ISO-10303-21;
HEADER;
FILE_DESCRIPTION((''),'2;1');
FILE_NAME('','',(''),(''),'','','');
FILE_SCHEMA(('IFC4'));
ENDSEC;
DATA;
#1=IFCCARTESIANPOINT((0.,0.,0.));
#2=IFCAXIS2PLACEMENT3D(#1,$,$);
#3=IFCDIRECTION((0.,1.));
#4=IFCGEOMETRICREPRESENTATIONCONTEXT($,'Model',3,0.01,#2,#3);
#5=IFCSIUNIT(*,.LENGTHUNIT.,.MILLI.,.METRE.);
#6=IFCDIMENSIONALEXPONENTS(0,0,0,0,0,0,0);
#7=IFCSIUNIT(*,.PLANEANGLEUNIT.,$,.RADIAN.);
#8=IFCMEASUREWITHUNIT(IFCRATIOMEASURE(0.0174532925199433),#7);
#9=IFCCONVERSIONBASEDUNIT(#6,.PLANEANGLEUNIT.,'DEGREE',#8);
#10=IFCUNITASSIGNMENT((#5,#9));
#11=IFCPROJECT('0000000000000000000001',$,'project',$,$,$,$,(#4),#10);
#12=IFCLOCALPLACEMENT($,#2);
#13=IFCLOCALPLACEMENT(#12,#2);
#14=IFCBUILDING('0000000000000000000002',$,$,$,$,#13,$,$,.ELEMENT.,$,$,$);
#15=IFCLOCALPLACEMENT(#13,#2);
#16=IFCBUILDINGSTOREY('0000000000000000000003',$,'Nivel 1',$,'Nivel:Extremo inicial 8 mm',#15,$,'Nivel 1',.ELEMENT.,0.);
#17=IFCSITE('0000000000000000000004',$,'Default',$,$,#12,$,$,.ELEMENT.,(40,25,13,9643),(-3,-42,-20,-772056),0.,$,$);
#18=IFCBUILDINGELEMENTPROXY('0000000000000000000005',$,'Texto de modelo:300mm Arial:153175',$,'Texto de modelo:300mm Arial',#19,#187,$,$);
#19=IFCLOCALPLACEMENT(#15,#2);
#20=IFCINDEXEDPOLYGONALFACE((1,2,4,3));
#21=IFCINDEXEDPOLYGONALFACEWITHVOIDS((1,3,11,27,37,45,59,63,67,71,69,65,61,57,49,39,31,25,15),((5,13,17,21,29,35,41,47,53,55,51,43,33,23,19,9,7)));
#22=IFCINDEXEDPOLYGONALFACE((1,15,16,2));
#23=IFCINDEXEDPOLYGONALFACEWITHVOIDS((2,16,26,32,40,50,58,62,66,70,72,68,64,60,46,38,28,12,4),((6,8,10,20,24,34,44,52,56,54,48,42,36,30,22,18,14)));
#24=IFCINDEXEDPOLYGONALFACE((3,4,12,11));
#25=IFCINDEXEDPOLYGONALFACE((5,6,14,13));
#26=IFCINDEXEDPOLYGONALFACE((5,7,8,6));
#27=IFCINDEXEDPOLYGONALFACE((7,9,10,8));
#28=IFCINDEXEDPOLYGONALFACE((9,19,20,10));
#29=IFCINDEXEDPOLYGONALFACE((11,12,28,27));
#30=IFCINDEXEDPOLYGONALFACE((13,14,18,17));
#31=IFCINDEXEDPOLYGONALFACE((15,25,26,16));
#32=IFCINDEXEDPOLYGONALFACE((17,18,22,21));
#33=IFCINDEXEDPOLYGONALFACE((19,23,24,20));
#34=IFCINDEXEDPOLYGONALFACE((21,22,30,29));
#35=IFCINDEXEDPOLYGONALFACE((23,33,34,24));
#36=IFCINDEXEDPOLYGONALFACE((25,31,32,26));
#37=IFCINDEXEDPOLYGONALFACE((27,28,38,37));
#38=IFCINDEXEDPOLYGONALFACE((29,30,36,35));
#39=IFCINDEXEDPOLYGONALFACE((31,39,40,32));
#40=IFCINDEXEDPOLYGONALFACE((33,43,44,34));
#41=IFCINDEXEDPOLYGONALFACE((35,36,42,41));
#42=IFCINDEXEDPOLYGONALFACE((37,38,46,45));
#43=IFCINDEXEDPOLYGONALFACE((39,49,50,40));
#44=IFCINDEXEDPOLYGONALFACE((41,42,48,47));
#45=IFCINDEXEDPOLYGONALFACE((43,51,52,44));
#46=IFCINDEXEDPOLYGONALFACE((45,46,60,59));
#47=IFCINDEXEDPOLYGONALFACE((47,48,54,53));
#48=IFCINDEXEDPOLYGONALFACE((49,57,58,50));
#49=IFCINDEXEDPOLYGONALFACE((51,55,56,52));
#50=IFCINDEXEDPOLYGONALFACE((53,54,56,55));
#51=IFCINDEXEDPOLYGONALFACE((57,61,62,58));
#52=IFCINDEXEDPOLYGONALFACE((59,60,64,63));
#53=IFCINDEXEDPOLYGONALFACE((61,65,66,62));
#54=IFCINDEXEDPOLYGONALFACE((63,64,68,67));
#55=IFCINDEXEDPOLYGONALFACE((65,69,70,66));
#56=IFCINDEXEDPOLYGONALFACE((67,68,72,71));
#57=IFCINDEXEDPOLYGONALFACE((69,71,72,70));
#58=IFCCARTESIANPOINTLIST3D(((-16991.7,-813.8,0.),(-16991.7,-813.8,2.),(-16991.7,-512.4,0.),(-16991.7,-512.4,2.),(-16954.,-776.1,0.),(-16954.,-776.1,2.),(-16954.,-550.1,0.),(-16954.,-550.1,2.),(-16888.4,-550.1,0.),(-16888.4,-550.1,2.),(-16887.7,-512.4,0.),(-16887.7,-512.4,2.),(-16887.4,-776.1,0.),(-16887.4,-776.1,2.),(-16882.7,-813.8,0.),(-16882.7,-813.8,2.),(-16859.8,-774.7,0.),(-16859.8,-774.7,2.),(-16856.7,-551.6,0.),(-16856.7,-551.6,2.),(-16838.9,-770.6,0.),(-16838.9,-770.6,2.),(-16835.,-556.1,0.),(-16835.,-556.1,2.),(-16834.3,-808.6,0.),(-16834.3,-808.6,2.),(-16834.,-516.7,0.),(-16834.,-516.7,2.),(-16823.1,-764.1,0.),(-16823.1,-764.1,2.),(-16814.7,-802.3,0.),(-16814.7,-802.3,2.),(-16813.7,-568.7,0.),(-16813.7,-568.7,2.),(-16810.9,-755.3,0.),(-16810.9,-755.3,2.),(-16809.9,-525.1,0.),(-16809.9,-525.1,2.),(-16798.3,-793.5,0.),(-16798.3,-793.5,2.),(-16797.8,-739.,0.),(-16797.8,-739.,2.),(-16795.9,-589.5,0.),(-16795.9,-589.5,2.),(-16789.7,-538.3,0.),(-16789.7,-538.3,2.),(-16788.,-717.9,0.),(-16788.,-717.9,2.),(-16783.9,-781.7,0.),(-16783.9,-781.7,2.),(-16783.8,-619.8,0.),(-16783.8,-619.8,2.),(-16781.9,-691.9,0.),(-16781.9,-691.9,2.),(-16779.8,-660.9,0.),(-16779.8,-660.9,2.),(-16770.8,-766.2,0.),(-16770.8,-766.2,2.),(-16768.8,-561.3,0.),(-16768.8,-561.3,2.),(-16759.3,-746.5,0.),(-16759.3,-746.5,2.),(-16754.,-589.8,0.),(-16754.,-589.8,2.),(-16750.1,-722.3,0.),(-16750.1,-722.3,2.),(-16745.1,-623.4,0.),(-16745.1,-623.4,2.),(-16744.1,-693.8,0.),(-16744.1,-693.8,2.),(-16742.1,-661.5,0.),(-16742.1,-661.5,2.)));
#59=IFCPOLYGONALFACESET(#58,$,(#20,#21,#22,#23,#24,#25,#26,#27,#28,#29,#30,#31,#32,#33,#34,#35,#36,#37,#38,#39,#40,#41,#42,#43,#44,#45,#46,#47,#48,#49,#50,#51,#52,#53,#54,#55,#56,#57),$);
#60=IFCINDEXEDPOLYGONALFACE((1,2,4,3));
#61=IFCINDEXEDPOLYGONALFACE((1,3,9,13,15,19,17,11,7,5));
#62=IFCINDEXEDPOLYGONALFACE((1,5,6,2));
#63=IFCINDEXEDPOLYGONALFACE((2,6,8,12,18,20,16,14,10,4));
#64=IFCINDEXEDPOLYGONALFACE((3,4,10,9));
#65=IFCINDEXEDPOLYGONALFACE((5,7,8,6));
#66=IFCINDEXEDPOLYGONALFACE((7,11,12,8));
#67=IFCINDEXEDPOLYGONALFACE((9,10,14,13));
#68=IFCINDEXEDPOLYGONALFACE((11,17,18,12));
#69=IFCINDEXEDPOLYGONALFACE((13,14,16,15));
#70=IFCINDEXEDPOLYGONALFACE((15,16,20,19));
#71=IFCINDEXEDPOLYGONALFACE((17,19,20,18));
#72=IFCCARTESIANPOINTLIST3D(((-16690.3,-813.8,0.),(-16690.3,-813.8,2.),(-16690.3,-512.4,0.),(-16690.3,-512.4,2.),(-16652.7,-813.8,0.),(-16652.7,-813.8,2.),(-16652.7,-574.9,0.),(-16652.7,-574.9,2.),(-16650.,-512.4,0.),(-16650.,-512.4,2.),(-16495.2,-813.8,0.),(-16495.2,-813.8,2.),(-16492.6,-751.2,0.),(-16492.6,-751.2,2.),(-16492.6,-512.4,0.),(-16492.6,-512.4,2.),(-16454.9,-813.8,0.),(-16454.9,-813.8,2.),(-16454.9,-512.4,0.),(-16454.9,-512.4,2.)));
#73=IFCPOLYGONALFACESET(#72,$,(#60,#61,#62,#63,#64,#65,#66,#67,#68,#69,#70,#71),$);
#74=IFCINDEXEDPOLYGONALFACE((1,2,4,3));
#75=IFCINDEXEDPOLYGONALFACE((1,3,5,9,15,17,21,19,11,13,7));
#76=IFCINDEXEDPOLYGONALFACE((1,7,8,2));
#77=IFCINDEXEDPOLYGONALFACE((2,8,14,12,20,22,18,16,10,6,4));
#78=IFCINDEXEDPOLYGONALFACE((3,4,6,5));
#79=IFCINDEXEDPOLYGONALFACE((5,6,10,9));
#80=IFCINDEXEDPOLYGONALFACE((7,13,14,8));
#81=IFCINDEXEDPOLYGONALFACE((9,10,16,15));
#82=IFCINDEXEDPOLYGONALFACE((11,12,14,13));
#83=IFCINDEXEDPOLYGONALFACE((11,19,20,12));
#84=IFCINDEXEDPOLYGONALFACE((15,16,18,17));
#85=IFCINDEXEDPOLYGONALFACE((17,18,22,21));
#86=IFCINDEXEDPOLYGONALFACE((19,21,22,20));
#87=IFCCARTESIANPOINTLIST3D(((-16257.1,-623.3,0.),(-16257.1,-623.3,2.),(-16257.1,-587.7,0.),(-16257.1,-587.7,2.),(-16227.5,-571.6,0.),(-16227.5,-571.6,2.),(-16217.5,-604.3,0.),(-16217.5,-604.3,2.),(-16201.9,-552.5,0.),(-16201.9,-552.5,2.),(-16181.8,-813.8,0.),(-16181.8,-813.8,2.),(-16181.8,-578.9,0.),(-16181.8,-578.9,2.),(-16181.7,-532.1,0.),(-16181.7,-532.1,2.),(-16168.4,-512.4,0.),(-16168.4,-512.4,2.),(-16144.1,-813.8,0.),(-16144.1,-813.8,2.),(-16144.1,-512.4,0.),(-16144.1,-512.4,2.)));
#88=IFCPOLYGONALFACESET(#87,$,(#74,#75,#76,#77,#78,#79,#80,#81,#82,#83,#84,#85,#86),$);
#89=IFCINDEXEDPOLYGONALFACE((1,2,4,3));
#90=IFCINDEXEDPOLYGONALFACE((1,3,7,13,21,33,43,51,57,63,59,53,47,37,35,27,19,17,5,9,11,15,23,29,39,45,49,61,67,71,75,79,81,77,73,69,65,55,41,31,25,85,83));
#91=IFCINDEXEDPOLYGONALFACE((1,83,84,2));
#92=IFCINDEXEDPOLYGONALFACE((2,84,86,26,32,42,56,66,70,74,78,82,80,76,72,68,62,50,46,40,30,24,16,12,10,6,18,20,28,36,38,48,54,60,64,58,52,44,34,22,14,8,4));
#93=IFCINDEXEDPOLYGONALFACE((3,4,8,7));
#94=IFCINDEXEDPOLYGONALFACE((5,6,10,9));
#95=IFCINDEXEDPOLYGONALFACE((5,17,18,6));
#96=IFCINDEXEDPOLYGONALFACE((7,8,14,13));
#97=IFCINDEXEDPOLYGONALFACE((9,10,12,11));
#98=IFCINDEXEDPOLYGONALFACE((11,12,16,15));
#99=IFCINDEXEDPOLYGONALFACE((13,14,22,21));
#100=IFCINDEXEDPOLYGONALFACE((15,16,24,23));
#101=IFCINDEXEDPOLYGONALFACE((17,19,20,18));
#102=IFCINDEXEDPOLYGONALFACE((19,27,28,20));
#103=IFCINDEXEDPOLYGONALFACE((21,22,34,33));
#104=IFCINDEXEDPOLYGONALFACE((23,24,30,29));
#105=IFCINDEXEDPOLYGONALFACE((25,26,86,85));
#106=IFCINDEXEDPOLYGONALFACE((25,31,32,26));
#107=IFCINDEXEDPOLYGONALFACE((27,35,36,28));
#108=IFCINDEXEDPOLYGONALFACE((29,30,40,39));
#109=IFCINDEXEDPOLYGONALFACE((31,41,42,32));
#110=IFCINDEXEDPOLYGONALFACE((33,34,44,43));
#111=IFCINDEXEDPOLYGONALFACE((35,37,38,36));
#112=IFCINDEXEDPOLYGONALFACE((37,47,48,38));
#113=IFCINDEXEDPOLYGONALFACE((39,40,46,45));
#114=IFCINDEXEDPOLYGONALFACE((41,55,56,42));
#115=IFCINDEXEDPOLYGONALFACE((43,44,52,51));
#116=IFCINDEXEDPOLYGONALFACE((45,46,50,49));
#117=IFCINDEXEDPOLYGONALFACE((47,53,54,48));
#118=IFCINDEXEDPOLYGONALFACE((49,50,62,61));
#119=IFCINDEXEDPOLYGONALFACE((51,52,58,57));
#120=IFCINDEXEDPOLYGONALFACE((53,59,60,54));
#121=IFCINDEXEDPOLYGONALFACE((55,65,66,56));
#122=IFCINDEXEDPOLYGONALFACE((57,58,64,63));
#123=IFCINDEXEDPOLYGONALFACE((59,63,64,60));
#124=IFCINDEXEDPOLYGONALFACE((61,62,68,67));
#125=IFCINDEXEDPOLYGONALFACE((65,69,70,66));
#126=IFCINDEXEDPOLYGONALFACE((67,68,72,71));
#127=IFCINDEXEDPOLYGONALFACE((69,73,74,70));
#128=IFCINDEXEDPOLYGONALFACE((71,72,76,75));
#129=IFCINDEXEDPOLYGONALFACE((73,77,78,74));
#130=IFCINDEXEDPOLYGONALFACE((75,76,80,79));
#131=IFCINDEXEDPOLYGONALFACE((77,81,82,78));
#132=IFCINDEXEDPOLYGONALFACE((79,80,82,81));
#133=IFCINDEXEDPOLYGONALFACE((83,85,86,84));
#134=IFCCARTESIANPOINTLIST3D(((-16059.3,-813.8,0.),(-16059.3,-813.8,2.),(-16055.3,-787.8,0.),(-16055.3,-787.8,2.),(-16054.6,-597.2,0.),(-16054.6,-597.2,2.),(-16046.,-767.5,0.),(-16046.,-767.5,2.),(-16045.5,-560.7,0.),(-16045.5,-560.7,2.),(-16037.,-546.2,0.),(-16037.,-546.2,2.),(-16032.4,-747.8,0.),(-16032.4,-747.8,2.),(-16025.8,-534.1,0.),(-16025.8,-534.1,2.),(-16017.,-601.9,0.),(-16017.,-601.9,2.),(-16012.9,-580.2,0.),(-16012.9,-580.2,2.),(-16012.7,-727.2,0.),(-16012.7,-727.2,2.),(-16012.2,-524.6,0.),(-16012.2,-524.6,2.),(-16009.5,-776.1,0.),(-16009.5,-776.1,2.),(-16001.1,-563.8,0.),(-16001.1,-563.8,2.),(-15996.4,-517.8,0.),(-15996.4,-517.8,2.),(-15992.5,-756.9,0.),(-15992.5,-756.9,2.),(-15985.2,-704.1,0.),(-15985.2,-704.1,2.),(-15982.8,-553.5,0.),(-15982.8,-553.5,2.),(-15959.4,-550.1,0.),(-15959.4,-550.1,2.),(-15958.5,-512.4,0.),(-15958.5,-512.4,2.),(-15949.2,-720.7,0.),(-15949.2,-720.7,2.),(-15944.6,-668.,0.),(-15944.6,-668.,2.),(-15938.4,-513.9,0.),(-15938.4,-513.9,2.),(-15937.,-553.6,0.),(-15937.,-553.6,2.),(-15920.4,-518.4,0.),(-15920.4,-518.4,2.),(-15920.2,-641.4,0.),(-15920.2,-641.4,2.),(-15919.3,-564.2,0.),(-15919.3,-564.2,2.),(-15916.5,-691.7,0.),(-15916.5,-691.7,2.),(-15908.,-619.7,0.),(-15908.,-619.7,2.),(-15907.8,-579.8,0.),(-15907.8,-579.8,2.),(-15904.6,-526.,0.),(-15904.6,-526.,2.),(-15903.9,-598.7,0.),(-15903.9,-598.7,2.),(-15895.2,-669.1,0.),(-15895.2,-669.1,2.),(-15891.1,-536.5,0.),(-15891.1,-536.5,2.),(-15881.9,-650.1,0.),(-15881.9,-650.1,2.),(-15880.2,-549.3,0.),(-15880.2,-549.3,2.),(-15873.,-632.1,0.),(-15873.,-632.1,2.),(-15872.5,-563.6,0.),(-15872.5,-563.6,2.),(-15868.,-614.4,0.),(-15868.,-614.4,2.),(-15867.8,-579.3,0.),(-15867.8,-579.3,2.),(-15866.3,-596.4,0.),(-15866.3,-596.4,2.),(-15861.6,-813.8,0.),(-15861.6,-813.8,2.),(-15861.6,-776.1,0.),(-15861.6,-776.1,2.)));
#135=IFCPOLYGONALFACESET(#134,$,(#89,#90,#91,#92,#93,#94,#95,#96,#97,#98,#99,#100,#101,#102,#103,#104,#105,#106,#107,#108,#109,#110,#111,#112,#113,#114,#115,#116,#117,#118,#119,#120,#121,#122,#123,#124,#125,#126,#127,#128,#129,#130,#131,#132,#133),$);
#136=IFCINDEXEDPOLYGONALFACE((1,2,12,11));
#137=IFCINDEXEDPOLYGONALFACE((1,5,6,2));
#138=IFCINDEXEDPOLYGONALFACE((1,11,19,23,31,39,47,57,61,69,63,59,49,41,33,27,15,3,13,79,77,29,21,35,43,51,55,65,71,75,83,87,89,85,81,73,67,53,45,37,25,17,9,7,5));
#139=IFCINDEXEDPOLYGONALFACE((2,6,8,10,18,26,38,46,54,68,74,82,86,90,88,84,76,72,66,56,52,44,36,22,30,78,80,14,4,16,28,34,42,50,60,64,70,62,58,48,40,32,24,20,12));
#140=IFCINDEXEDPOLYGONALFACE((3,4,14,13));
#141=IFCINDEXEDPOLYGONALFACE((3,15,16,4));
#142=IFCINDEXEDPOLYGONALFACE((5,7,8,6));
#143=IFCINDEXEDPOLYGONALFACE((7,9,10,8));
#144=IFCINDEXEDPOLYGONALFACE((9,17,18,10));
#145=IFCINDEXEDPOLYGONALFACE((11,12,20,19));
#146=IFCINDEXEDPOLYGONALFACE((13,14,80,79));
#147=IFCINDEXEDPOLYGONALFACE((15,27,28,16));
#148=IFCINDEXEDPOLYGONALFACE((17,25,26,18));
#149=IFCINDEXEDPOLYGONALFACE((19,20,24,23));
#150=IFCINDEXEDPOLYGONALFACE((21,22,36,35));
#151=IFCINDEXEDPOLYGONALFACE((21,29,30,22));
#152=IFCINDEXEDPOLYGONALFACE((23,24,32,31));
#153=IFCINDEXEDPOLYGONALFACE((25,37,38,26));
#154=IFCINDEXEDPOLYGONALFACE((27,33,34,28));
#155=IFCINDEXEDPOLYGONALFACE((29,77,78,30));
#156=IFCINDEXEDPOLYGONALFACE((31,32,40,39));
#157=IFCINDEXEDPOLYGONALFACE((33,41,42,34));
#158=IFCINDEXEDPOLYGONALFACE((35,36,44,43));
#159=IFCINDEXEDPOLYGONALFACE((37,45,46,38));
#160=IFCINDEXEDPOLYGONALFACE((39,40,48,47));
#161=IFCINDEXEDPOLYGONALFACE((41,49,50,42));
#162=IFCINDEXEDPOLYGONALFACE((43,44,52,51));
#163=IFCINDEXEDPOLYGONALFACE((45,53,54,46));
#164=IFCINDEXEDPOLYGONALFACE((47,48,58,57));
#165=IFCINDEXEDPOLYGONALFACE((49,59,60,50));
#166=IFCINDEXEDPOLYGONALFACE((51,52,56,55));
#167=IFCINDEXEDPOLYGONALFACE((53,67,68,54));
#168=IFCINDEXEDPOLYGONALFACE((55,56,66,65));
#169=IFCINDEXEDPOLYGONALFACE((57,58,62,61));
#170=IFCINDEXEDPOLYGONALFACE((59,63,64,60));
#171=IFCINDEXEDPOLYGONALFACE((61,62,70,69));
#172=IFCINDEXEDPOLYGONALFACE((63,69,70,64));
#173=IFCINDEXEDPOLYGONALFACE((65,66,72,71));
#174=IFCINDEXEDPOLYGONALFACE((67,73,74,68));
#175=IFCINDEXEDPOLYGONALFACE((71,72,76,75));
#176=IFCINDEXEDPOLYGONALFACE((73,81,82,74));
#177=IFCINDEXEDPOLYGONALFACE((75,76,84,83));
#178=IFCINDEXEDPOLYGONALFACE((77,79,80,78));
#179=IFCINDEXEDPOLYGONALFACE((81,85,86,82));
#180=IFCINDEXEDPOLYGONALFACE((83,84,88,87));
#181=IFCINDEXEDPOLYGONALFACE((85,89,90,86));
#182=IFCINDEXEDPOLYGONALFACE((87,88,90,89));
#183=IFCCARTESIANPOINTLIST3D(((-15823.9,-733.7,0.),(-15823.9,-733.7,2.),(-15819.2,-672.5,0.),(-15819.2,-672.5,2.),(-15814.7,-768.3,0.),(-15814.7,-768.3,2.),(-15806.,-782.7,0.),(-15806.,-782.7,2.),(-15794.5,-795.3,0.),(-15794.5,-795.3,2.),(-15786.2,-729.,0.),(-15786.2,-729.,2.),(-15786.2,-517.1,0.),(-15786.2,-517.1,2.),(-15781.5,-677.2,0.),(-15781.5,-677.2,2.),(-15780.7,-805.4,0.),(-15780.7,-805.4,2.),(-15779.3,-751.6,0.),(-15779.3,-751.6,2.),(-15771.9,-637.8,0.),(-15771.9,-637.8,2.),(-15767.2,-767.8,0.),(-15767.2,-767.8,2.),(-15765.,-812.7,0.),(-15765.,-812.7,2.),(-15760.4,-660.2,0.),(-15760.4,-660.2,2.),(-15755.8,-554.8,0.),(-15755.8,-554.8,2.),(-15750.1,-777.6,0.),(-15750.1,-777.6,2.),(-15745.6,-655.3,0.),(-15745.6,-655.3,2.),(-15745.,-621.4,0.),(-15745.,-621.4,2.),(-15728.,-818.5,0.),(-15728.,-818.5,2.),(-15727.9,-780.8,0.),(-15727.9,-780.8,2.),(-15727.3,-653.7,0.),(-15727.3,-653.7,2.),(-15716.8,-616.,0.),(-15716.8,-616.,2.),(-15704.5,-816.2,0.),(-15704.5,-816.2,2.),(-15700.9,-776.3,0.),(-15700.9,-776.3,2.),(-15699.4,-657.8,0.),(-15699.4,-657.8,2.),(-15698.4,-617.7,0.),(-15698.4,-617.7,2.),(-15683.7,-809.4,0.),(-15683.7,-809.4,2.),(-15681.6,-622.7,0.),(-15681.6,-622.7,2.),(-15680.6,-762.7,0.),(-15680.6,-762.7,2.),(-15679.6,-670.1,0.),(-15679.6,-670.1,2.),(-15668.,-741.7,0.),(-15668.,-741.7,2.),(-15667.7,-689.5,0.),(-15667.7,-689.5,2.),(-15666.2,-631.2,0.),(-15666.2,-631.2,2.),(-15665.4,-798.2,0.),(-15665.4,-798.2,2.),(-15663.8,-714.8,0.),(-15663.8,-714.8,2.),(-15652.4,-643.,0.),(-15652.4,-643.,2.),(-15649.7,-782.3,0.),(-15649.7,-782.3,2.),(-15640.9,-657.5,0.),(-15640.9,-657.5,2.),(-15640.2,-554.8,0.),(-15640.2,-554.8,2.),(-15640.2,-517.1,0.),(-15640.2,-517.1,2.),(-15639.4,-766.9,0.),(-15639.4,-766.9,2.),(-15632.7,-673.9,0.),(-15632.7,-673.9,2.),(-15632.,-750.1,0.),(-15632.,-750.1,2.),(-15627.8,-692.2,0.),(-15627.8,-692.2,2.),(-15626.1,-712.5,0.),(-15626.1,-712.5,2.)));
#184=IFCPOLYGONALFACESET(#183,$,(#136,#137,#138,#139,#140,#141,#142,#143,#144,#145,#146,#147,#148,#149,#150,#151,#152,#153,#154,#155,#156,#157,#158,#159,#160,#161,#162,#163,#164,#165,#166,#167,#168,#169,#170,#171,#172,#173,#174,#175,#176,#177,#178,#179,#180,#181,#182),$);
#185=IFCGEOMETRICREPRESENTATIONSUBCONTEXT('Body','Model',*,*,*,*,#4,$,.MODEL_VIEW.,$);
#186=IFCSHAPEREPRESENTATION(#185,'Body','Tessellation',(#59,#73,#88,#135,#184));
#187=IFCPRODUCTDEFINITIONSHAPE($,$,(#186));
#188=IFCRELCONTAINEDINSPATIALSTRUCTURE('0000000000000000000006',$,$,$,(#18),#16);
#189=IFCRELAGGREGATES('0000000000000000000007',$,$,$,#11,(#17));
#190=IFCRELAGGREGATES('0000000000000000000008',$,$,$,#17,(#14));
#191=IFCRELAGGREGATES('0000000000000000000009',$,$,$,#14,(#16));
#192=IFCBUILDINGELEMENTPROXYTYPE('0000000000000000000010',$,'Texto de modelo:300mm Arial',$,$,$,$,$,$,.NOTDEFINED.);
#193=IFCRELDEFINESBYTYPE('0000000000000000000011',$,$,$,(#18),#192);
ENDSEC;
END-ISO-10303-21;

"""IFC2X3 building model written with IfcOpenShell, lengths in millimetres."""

from ifc_helpers import new_model, entity, si_unit, converted_unit, direction, frame, origin, place, context, subcontext, project, spatial, polyline, outline, extrude, type_object, element, save


model = new_model("IFC2X3")

# Units and contexts
model_context = context("Model", 3, precision=0.01, world=origin(), true_north=direction((0.0, 1.0)))
body_context = subcontext(model_context, "Body", "Model", "MODEL_VIEW")
ifc_project = project(units=[si_unit("LENGTHUNIT", "METRE", prefix="MILLI"), converted_unit("PLANEANGLEUNIT", "DEGREE", entity("IfcRatioMeasure", 0.0174532925199433), si_unit("PLANEANGLEUNIT", "RADIAN"), dimensions=[0, 0, 0, 0, 0, 0, 0])], contexts=[model_context])

# Site, building, storey
site_placement = place(None, origin())
site = spatial("IfcSite", under=ifc_project, at=site_placement, Name="Default", CompositionType="ELEMENT", RefLatitude=(40, 25, 13, 9643), RefLongitude=(-3, -42, -20, -772056), RefElevation=0.0)
building_placement = place(site_placement, origin())
building = spatial("IfcBuilding", under=site, at=building_placement, CompositionType="ELEMENT")
storey_placement = place(building_placement, origin())
storey = spatial("IfcBuildingStorey", under=building, at=storey_placement, Name="Nivel 1", ObjectType="Nivel:Extremo inicial 8 mm", LongName="Nivel 1", CompositionType="ELEMENT", Elevation=0.0)

# Building element proxy
building_element_proxy_type_1 = type_object("IfcBuildingElementProxyType", Name="Texto de modelo:300mm Arial", PredefinedType="NOTDEFINED")
proxy_1_placement = place(storey_placement, frame((-16991.7, -818.5, 0.0)))
element("IfcBuildingElementProxy", 1, at=proxy_1_placement, inside=storey, type_object=building_element_proxy_type_1, Name="Texto de modelo:300mm Arial:153175", ObjectType="Texto de modelo:300mm Arial", context=body_context, shape_type="SweptSolid", body=[
    extrude(outline(polyline([(-178.4, -141.0), (-69.4, -141.0), (-21.0, -135.8), (-1.4, -129.5), (15.0, -120.7), (29.4, -108.9), (42.6, -93.4), (54.0, -73.7), (63.2, -49.5), (69.2, -21.0), (71.2, 11.3), (68.2, 49.4), (59.3, 83.0), (44.5, 111.5), (23.7, 134.5), (3.4, 147.7), (-20.6, 156.1), (-74.4, 160.4), (-178.4, 160.4), (-178.4, -141.0)]), holes=[polyline([(-140.7, -103.3), (-140.7, 122.7), (-75.1, 122.7), (-43.3, 121.2), (-21.7, 116.7), (-0.4, 104.1), (17.4, 83.3), (29.5, 53.0), (33.5, 11.9), (31.5, -19.1), (25.3, -45.1), (15.5, -66.2), (2.4, -82.5), (-9.8, -91.3), (-25.6, -97.9), (-46.5, -101.9), (-74.1, -103.3), (-140.7, -103.3)])]), frame((178.4, 145.7, 0.0)), (0.0, 0.0, 1.0), 2.0),
    extrude(outline(polyline([(-117.7, -150.7), (-80.1, -150.7), (-80.1, 88.1), (77.4, -150.7), (117.7, -150.7), (117.7, 150.7), (80.1, 150.7), (80.1, -88.1), (-77.4, 150.7), (-117.7, 150.7), (-117.7, -150.7)])), frame((419.1, 155.4, 0.0)), (0.0, 0.0, 1.0), 2.0),
    extrude(outline(polyline([(-204.4, -52.5), (97.0, -52.5), (97.0, -28.2), (77.2, -14.9), (56.9, 5.3), (37.7, 30.9), (21.6, 60.5), (-14.0, 60.5), (5.0, 20.8), (30.4, -14.9), (-204.4, -14.9), (-204.4, -52.5)])), frame((795.1, 209.1, 0.0), z_axis=(0.0, 0.0, 1.0), x_axis=(0.0, 1.0, 0.0)), (0.0, 0.0, 1.0), 2.0),
    extrude(outline(polyline([(-91.6, -150.5), (-91.6, -188.2), (106.2, -188.2), (102.1, -162.2), (92.9, -141.9), (79.3, -122.2), (59.6, -101.6), (32.1, -78.5), (-8.5, -42.4), (-32.9, -15.8), (-45.1, 5.8), (-49.2, 26.9), (-45.4, 45.8), (-33.9, 61.4), (-16.2, 72.0), (6.2, 75.5), (29.7, 72.1), (48.0, 61.8), (59.7, 45.4), (63.8, 23.7), (101.5, 28.4), (92.4, 64.9), (83.8, 79.4), (72.6, 91.5), (59.0, 101.0), (43.3, 107.8), (5.4, 113.2), (-14.8, 111.7), (-32.8, 107.2), (-48.5, 99.6), (-62.0, 89.1), (-72.9, 76.3), (-80.7, 62.0), (-85.3, 46.3), (-86.9, 29.2), (-85.2, 11.2), (-80.2, -6.5), (-71.3, -24.6), (-57.9, -43.5), (-36.6, -66.1), (-3.9, -95.1), (39.4, -131.3), (56.4, -150.5), (-91.6, -150.5)])), frame((1038.6, 192.9, 0.0), z_axis=(0.0, 0.0, -1.0), x_axis=(-1.0, 0.0, 0.0)), (0.0, 0.0, -1.0), 2.0),
    extrude(outline(polyline([(1.4, -113.1), (37.2, -113.1), (53.4, -108.4), (68.5, -100.5), (81.8, -89.8), (92.9, -76.5), (108.0, -42.2), (111.8, -18.9), (110.6, 3.0), (104.4, 23.5), (93.2, 42.7), (80.9, 56.7), (66.6, 68.1), (31.7, 83.5), (11.7, 87.1), (-7.3, 87.1), (-25.2, 83.4), (-42.2, 76.0), (-57.1, 65.7), (-69.2, 53.0), (-78.5, 38.0), (-84.8, 20.7), (-86.8, -7.9), (-77.9, -38.1), (-154.0, -1.2), (-124.3, 110.4), (-160.7, 120.1), (-198.2, -21.0), (-56.5, -92.8), (-42.3, -57.6), (-53.3, -32.8), (-54.2, -17.2), (-51.1, 0.9), (-40.0, 26.8), (-23.0, 42.8), (-1.2, 49.2), (24.3, 46.5), (49.2, 35.5), (66.3, 17.9), (74.2, -5.1), (71.6, -32.4), (62.8, -53.0), (48.9, -67.1), (30.2, -74.6), (6.6, -75.5), (1.4, -113.1)])), frame((1276.7, 115.2, 0.0), z_axis=(0.0, 0.0, 1.0), x_axis=(0.256974, -0.966418, 0.0)), (0.0, 0.0, 1.0), 2.0),
])

save(model, "model.ifc")
